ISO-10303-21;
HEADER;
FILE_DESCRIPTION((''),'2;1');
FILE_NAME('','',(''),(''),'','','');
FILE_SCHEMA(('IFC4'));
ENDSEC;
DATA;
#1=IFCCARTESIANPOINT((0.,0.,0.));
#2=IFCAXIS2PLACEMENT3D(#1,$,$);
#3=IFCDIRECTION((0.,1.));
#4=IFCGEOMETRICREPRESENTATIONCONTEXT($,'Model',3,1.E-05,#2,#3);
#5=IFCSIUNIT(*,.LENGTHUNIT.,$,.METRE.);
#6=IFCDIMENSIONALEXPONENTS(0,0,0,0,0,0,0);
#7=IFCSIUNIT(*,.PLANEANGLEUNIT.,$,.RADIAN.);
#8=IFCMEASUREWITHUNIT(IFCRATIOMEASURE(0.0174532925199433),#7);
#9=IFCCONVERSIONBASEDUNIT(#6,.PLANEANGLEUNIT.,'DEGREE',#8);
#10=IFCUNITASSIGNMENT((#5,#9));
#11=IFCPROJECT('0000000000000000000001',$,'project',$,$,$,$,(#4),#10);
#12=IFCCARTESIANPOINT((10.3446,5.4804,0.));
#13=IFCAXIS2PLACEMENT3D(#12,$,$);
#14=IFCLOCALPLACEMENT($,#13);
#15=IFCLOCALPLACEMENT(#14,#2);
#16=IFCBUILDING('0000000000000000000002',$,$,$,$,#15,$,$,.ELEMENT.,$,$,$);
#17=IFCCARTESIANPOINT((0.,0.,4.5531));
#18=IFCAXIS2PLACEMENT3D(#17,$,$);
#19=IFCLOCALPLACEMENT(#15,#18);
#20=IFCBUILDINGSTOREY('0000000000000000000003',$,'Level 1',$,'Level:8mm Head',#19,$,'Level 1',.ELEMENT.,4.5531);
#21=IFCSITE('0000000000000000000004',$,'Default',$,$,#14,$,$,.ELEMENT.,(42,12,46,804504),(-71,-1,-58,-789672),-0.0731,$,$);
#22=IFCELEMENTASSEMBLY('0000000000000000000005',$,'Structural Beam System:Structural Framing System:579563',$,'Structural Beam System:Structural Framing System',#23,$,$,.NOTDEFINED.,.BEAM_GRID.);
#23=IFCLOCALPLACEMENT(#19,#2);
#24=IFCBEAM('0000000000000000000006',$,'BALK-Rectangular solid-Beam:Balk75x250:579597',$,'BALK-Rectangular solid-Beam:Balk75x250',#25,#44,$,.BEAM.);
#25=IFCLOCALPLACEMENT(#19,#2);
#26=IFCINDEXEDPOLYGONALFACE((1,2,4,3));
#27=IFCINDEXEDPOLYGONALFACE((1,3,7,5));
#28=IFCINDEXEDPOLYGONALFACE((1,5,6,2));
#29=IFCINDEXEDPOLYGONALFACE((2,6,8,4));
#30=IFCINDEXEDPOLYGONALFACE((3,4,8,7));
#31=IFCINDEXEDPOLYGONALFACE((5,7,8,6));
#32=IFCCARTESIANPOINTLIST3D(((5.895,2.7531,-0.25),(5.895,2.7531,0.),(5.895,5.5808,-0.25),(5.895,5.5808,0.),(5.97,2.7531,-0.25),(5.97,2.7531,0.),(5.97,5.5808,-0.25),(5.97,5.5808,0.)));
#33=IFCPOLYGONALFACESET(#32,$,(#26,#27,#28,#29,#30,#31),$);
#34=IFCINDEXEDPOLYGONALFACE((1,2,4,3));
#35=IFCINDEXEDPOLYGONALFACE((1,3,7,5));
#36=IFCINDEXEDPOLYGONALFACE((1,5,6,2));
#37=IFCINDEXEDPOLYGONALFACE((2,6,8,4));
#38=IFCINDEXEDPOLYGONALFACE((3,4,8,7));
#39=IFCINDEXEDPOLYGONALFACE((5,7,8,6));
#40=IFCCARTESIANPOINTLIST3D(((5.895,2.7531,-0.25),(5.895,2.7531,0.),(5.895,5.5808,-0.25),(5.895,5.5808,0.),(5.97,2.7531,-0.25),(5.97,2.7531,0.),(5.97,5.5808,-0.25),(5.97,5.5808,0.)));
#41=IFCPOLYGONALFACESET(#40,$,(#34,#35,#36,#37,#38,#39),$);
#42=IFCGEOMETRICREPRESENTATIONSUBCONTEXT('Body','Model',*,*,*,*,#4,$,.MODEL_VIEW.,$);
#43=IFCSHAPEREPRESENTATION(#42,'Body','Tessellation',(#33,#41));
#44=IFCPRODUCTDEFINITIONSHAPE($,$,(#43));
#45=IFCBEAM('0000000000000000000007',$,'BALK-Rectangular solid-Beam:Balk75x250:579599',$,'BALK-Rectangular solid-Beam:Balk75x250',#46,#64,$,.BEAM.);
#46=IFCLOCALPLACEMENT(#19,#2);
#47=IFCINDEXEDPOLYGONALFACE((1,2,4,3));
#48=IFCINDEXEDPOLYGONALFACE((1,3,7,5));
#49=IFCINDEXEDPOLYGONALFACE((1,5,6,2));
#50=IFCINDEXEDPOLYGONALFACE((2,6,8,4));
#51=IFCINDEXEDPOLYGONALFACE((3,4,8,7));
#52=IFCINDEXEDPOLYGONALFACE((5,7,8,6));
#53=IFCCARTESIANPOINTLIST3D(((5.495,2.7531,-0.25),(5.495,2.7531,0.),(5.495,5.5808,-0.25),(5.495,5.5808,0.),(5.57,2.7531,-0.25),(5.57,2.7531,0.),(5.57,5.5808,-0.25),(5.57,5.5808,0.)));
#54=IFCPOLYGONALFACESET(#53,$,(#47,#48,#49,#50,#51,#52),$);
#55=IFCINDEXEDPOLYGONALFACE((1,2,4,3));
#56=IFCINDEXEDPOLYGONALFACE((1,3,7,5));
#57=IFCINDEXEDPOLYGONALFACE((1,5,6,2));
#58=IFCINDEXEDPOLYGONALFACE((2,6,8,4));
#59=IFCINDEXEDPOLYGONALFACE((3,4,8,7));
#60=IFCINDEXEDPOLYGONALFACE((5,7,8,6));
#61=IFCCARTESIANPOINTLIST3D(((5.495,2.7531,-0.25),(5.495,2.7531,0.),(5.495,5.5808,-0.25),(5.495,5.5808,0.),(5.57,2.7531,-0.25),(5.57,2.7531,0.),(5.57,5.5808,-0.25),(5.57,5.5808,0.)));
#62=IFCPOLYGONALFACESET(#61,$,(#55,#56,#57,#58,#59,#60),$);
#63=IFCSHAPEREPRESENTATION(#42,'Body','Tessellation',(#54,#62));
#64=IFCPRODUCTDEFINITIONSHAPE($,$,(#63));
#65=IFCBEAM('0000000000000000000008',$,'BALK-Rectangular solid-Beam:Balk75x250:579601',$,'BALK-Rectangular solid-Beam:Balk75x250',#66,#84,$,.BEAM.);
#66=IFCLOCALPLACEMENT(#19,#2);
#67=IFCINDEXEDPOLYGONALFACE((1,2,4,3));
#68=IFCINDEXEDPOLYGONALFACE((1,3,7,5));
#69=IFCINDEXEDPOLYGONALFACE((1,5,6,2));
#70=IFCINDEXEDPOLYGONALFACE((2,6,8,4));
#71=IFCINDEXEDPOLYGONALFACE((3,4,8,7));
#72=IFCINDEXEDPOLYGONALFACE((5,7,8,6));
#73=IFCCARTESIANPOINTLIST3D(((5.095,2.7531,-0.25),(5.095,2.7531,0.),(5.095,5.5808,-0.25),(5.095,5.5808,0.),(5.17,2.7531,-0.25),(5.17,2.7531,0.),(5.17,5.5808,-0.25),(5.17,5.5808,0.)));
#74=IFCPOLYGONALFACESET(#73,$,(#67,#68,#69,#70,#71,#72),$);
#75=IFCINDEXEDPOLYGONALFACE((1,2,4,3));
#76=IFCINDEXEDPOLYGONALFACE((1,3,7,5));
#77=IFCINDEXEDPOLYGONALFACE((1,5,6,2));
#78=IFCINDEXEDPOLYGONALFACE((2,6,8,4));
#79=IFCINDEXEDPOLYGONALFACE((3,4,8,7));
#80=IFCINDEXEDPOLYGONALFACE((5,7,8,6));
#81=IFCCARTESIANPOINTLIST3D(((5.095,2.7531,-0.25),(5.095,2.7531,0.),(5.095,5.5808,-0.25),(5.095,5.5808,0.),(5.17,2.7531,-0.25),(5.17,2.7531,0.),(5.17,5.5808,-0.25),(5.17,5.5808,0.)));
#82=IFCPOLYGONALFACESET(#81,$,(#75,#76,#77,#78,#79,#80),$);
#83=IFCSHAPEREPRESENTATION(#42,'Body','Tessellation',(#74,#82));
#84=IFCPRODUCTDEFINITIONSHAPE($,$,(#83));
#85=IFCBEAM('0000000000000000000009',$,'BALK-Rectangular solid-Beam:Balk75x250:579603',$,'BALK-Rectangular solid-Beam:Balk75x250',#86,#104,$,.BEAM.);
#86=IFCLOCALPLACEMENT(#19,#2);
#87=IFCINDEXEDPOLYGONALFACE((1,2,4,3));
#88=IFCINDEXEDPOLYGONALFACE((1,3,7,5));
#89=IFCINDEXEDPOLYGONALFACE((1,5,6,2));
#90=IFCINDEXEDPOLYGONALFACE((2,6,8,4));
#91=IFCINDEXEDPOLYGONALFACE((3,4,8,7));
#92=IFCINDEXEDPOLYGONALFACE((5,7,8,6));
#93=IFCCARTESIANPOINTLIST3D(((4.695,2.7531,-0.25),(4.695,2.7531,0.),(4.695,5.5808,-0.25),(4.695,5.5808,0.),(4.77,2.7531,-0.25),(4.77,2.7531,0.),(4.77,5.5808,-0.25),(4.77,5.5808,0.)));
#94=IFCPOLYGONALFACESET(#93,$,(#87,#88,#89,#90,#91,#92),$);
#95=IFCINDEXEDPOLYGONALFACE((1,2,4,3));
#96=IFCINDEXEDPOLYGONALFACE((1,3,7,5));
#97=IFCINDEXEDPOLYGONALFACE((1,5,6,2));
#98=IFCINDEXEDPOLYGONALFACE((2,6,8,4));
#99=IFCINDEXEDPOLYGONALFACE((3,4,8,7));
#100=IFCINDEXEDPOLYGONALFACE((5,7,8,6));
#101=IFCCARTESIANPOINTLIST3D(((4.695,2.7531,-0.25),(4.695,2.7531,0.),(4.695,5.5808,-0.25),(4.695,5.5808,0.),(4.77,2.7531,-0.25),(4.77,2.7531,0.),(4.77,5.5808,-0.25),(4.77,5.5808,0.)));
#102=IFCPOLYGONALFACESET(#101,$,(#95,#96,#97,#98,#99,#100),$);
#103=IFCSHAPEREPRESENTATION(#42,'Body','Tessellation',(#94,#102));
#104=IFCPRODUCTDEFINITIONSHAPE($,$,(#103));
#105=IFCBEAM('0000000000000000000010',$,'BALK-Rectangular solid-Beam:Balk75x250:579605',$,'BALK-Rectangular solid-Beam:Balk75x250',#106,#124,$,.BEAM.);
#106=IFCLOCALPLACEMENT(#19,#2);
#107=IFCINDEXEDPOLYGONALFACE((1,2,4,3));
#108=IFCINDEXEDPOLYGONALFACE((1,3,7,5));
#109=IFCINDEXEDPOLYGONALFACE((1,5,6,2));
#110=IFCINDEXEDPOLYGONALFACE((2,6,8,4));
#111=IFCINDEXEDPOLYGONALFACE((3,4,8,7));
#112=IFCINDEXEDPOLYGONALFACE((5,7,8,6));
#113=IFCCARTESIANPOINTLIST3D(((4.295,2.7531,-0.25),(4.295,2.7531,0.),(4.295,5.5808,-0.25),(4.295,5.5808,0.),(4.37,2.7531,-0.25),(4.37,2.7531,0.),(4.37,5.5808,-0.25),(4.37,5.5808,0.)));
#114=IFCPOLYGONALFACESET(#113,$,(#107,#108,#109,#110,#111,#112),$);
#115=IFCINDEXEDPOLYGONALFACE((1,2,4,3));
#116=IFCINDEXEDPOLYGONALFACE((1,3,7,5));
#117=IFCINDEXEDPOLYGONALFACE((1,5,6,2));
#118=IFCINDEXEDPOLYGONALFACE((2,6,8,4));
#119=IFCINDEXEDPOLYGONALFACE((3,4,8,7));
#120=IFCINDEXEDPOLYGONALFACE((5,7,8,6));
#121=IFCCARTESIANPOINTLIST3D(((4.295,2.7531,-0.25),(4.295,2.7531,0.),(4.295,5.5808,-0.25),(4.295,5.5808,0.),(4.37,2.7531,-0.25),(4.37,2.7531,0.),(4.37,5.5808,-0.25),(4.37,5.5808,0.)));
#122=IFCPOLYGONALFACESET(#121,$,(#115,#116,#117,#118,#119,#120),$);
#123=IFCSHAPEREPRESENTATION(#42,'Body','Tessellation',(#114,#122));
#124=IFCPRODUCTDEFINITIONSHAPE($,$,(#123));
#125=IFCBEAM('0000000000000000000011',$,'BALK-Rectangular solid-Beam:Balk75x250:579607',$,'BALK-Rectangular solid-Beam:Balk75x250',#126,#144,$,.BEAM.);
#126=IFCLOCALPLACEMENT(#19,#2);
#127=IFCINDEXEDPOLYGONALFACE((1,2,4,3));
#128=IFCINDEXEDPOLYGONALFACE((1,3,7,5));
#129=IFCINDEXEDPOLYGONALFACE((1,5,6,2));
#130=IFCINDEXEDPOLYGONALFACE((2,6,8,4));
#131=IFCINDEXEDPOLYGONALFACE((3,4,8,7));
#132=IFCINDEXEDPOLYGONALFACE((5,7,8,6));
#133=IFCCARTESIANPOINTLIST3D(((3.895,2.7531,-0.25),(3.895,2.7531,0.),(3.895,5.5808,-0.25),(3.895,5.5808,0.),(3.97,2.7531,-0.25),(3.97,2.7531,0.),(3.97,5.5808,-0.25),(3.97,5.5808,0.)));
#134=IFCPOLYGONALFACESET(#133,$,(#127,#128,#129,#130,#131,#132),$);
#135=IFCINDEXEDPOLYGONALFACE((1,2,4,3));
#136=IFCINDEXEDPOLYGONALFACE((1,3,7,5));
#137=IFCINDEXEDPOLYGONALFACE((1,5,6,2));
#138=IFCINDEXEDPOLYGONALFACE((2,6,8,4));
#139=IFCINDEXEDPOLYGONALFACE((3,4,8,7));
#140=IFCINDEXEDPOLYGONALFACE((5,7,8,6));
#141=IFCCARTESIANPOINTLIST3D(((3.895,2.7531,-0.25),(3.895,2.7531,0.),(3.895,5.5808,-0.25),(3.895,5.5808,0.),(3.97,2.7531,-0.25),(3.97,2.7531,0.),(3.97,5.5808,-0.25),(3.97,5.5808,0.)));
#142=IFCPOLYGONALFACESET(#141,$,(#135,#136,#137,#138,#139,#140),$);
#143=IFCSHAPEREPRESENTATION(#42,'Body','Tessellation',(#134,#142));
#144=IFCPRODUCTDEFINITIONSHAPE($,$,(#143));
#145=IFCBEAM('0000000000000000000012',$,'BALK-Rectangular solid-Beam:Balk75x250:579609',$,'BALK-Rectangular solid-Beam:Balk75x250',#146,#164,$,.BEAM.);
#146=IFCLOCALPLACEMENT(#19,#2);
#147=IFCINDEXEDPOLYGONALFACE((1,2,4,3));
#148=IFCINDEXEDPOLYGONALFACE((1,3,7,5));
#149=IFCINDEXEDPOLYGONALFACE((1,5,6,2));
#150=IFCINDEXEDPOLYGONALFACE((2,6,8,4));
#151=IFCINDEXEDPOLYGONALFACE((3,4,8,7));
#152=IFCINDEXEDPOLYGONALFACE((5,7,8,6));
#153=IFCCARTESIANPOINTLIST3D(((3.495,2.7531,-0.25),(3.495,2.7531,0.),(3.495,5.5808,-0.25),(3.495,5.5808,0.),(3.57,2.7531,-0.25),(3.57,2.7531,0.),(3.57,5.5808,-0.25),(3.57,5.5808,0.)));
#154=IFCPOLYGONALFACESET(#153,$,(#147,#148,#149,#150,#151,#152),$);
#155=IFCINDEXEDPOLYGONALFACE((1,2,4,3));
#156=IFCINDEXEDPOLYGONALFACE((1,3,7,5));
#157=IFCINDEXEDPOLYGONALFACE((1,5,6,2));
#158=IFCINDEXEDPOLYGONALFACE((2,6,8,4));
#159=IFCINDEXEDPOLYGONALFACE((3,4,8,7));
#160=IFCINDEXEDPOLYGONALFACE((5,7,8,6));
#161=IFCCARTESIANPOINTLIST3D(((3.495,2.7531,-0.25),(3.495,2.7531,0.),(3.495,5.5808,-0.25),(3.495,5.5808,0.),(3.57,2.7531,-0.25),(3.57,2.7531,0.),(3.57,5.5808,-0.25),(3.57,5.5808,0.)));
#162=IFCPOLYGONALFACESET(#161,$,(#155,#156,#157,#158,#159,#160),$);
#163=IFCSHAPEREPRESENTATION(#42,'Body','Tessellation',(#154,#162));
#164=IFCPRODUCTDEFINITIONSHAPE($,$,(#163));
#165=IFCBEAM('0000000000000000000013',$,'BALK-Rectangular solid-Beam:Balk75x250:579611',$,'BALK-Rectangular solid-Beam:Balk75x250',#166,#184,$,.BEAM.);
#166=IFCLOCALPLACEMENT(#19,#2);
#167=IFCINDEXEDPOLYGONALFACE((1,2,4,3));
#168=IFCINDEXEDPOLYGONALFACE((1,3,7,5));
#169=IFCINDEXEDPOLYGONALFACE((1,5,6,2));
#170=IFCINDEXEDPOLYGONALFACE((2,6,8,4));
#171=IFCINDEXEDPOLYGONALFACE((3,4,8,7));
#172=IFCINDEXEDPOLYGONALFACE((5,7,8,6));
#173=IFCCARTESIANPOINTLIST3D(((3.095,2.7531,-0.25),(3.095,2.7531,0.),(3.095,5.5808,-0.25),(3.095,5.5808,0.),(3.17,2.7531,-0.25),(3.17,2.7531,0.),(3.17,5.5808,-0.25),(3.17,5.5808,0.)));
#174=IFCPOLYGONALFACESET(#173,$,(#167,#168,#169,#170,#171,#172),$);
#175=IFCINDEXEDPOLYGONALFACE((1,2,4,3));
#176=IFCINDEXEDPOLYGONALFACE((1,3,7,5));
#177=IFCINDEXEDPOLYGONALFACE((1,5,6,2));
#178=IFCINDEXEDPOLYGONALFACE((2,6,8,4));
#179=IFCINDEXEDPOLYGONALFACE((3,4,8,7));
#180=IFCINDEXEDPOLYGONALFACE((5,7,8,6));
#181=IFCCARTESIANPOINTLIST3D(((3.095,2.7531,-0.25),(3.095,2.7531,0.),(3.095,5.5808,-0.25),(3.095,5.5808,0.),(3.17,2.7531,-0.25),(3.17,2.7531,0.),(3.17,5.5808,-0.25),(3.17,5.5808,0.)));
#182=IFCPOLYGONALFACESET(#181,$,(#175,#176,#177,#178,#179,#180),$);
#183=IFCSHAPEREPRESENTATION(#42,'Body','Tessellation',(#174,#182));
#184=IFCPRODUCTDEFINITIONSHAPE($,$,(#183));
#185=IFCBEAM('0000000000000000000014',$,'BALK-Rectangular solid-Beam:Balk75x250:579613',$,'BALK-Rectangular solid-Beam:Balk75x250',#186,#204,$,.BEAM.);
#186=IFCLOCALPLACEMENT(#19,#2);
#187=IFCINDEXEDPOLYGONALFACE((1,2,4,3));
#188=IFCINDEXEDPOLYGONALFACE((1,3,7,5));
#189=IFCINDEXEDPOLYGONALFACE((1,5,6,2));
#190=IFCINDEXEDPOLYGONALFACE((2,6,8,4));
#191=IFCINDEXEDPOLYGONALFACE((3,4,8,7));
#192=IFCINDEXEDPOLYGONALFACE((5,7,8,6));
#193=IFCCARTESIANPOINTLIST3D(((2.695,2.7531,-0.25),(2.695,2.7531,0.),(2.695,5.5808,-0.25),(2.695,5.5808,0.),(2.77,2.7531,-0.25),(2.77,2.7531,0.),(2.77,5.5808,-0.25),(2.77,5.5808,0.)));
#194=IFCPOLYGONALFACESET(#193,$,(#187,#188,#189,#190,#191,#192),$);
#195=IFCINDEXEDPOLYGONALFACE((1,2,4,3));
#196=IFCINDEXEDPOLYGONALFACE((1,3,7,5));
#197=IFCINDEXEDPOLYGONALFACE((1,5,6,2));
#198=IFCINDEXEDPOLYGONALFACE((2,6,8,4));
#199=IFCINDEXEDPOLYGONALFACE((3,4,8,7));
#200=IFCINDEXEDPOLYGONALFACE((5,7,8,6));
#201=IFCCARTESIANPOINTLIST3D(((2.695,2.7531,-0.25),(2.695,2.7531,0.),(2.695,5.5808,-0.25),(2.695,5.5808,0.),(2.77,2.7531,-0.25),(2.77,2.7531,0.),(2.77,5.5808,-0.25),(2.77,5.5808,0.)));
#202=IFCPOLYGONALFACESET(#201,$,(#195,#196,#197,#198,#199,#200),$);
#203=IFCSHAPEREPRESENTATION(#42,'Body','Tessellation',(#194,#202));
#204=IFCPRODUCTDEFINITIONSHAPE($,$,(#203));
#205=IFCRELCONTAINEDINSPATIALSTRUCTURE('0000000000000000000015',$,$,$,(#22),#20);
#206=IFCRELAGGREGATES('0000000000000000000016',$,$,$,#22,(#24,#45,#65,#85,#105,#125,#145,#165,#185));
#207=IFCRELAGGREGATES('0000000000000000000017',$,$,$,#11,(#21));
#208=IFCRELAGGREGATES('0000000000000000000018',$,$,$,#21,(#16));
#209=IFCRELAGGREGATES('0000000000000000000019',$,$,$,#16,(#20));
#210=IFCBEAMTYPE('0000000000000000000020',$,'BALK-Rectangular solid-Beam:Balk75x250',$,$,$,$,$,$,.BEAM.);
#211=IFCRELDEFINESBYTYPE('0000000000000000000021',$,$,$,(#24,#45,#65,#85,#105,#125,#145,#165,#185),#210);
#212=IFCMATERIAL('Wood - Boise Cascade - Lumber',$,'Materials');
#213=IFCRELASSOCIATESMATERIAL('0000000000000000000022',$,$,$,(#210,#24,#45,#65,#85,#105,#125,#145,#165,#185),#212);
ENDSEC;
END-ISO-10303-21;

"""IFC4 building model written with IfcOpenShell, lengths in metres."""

from ifc_helpers import new_model, entity, si_unit, converted_unit, direction, frame, frame_2d, origin, origin_2d_with_axis, place, context, subcontext, project, spatial, rectangle, extrude, source, transform, mapped, material, material_profile, profile_set, profile_usage, type_object, type_shapes, element, aggregate, save


model = new_model("IFC4")

# Units and contexts
model_context = context("Model", 3, precision=1e-05, world=origin(), true_north=direction((0.0, 1.0)))
body_context = subcontext(model_context, "Body", "Model", "MODEL_VIEW")
ifc_project = project(units=[si_unit("LENGTHUNIT", "METRE"), converted_unit("PLANEANGLEUNIT", "DEGREE", entity("IfcRatioMeasure", 0.0174532925199433), si_unit("PLANEANGLEUNIT", "RADIAN"), dimensions=[0, 0, 0, 0, 0, 0, 0])], contexts=[model_context])

# Site, building, storey
site_placement = place(None, frame((10.3446, 5.4804, 0.0)))
site = spatial("IfcSite", under=ifc_project, at=site_placement, Name="Default", CompositionType="ELEMENT", RefLatitude=(42, 12, 46, 804504), RefLongitude=(-71, -1, -58, -789672), RefElevation=-0.0731)
building_placement = place(site_placement, origin())
building = spatial("IfcBuilding", under=site, at=building_placement, CompositionType="ELEMENT")
storey_placement = place(building_placement, frame((0.0, 0.0, 4.5531)))
storey = spatial("IfcBuildingStorey", under=building, at=storey_placement, Name="Level 1", ObjectType="Level:8mm Head", LongName="Level 1", CompositionType="ELEMENT", Elevation=4.5531)

# Shared definitions
ifc_material_1 = material(Name="Wood - Boise Cascade - Lumber", Category="Materials")
ifc_material_profile = material_profile(ifc_material_1, rectangle(XDim=0.25, YDim=0.075, at=frame_2d((0.0, 0.0), x_axis=(1.0, 0.0))), Name="Balk75x250")
ifc_profile_set = profile_set([ifc_material_profile], Name="Balk75x250")

# Element assembly, beams
assembly_1_placement = place(storey_placement, origin())
assembly_1 = element("IfcElementAssembly", 1, at=assembly_1_placement, inside=storey, Name="Structural Beam System:Structural Framing System:579563", ObjectType="Structural Beam System:Structural Framing System", AssemblyPlace="NOTDEFINED", PredefinedType="BEAM_GRID")
ifc_profile_usage_1 = profile_usage(ifc_profile_set, cardinal=8)
beam_type_1 = type_object("IfcBeamType", Name="BALK-Rectangular solid-Beam:Balk75x250", PredefinedType="BEAM", material=ifc_profile_set)
shared_shape_1 = source(origin(), body_context, "Body", "SweptSolid", [
    extrude(rectangle(XDim=0.25, YDim=0.075, at=origin_2d_with_axis()), frame((-1.4138, 0.0, 0.0), z_axis=(1.0, 0.0, 0.0), x_axis=(0.0, 0.0, -1.0)), (0.0, 0.0, 1.0), 2.8276),
    extrude(rectangle(XDim=0.25, YDim=0.075, at=origin_2d_with_axis()), frame((-1.4138, 0.0, 0.0), z_axis=(1.0, 0.0, 0.0), x_axis=(0.0, 0.0, -1.0)), (0.0, 0.0, 1.0), 2.8276),
])
type_shapes(beam_type_1, [shared_shape_1])
beam_1_placement = place(assembly_1_placement, frame((5.9325, 4.167, -0.125), z_axis=(0.0, 0.0, 1.0), x_axis=(0.0, -1.0, 0.0)))
beam_1 = element("IfcBeam", 2, at=beam_1_placement, type_object=beam_type_1, material=ifc_profile_usage_1, Name="BALK-Rectangular solid-Beam:Balk75x250:579597", ObjectType="BALK-Rectangular solid-Beam:Balk75x250", PredefinedType="BEAM", context=body_context, shape_type="MappedRepresentation", body=[
    mapped(shared_shape_1, transform((0.0, 0.0, 0.0), scale=1.0)),
])
ifc_profile_usage_2 = profile_usage(ifc_profile_set, cardinal=8)
beam_2_placement = place(assembly_1_placement, frame((5.5325, 4.167, -0.125), z_axis=(0.0, 0.0, 1.0), x_axis=(0.0, -1.0, 0.0)))
beam_2 = element("IfcBeam", 3, at=beam_2_placement, type_object=beam_type_1, material=ifc_profile_usage_2, Name="BALK-Rectangular solid-Beam:Balk75x250:579599", ObjectType="BALK-Rectangular solid-Beam:Balk75x250", PredefinedType="BEAM", context=body_context, shape_type="MappedRepresentation", body=[
    mapped(shared_shape_1, transform((0.0, 0.0, 0.0), scale=1.0)),
])
ifc_profile_usage_3 = profile_usage(ifc_profile_set, cardinal=8)
beam_3_placement = place(assembly_1_placement, frame((5.1325, 4.167, -0.125), z_axis=(0.0, 0.0, 1.0), x_axis=(0.0, -1.0, 0.0)))
beam_3 = element("IfcBeam", 4, at=beam_3_placement, type_object=beam_type_1, material=ifc_profile_usage_3, Name="BALK-Rectangular solid-Beam:Balk75x250:579601", ObjectType="BALK-Rectangular solid-Beam:Balk75x250", PredefinedType="BEAM", context=body_context, shape_type="MappedRepresentation", body=[
    mapped(shared_shape_1, transform((0.0, 0.0, 0.0), scale=1.0)),
])
ifc_profile_usage_4 = profile_usage(ifc_profile_set, cardinal=8)
beam_4_placement = place(assembly_1_placement, frame((4.7325, 4.167, -0.125), z_axis=(0.0, 0.0, 1.0), x_axis=(0.0, -1.0, 0.0)))
beam_4 = element("IfcBeam", 5, at=beam_4_placement, type_object=beam_type_1, material=ifc_profile_usage_4, Name="BALK-Rectangular solid-Beam:Balk75x250:579603", ObjectType="BALK-Rectangular solid-Beam:Balk75x250", PredefinedType="BEAM", context=body_context, shape_type="MappedRepresentation", body=[
    mapped(shared_shape_1, transform((0.0, 0.0, 0.0), scale=1.0)),
])
ifc_profile_usage_5 = profile_usage(ifc_profile_set, cardinal=8)
beam_5_placement = place(assembly_1_placement, frame((4.3325, 4.167, -0.125), z_axis=(0.0, 0.0, 1.0), x_axis=(0.0, -1.0, 0.0)))
beam_5 = element("IfcBeam", 6, at=beam_5_placement, type_object=beam_type_1, material=ifc_profile_usage_5, Name="BALK-Rectangular solid-Beam:Balk75x250:579605", ObjectType="BALK-Rectangular solid-Beam:Balk75x250", PredefinedType="BEAM", context=body_context, shape_type="MappedRepresentation", body=[
    mapped(shared_shape_1, transform((0.0, 0.0, 0.0), scale=1.0)),
])
ifc_profile_usage_6 = profile_usage(ifc_profile_set, cardinal=8)
beam_6_placement = place(assembly_1_placement, frame((3.9325, 4.167, -0.125), z_axis=(0.0, 0.0, 1.0), x_axis=(0.0, -1.0, 0.0)))
beam_6 = element("IfcBeam", 7, at=beam_6_placement, type_object=beam_type_1, material=ifc_profile_usage_6, Name="BALK-Rectangular solid-Beam:Balk75x250:579607", ObjectType="BALK-Rectangular solid-Beam:Balk75x250", PredefinedType="BEAM", context=body_context, shape_type="MappedRepresentation", body=[
    mapped(shared_shape_1, transform((0.0, 0.0, 0.0), scale=1.0)),
])
ifc_profile_usage_7 = profile_usage(ifc_profile_set, cardinal=8)
beam_7_placement = place(assembly_1_placement, frame((3.5325, 4.167, -0.125), z_axis=(0.0, 0.0, 1.0), x_axis=(0.0, -1.0, 0.0)))
beam_7 = element("IfcBeam", 8, at=beam_7_placement, type_object=beam_type_1, material=ifc_profile_usage_7, Name="BALK-Rectangular solid-Beam:Balk75x250:579609", ObjectType="BALK-Rectangular solid-Beam:Balk75x250", PredefinedType="BEAM", context=body_context, shape_type="MappedRepresentation", body=[
    mapped(shared_shape_1, transform((0.0, 0.0, 0.0), scale=1.0)),
])
ifc_profile_usage_8 = profile_usage(ifc_profile_set, cardinal=8)
beam_8_placement = place(assembly_1_placement, frame((3.1325, 4.167, -0.125), z_axis=(0.0, 0.0, 1.0), x_axis=(0.0, -1.0, 0.0)))
beam_8 = element("IfcBeam", 9, at=beam_8_placement, type_object=beam_type_1, material=ifc_profile_usage_8, Name="BALK-Rectangular solid-Beam:Balk75x250:579611", ObjectType="BALK-Rectangular solid-Beam:Balk75x250", PredefinedType="BEAM", context=body_context, shape_type="MappedRepresentation", body=[
    mapped(shared_shape_1, transform((0.0, 0.0, 0.0), scale=1.0)),
])
ifc_profile_usage_9 = profile_usage(ifc_profile_set, cardinal=8)
beam_9_placement = place(assembly_1_placement, frame((2.7325, 4.167, -0.125), z_axis=(0.0, 0.0, 1.0), x_axis=(0.0, -1.0, 0.0)))
beam_9 = element("IfcBeam", 10, at=beam_9_placement, type_object=beam_type_1, material=ifc_profile_usage_9, Name="BALK-Rectangular solid-Beam:Balk75x250:579613", ObjectType="BALK-Rectangular solid-Beam:Balk75x250", PredefinedType="BEAM", context=body_context, shape_type="MappedRepresentation", body=[
    mapped(shared_shape_1, transform((0.0, 0.0, 0.0), scale=1.0)),
])
aggregate(assembly_1, [beam_1, beam_2, beam_3, beam_4, beam_5, beam_6, beam_7, beam_8, beam_9])

save(model, "model.ifc")
